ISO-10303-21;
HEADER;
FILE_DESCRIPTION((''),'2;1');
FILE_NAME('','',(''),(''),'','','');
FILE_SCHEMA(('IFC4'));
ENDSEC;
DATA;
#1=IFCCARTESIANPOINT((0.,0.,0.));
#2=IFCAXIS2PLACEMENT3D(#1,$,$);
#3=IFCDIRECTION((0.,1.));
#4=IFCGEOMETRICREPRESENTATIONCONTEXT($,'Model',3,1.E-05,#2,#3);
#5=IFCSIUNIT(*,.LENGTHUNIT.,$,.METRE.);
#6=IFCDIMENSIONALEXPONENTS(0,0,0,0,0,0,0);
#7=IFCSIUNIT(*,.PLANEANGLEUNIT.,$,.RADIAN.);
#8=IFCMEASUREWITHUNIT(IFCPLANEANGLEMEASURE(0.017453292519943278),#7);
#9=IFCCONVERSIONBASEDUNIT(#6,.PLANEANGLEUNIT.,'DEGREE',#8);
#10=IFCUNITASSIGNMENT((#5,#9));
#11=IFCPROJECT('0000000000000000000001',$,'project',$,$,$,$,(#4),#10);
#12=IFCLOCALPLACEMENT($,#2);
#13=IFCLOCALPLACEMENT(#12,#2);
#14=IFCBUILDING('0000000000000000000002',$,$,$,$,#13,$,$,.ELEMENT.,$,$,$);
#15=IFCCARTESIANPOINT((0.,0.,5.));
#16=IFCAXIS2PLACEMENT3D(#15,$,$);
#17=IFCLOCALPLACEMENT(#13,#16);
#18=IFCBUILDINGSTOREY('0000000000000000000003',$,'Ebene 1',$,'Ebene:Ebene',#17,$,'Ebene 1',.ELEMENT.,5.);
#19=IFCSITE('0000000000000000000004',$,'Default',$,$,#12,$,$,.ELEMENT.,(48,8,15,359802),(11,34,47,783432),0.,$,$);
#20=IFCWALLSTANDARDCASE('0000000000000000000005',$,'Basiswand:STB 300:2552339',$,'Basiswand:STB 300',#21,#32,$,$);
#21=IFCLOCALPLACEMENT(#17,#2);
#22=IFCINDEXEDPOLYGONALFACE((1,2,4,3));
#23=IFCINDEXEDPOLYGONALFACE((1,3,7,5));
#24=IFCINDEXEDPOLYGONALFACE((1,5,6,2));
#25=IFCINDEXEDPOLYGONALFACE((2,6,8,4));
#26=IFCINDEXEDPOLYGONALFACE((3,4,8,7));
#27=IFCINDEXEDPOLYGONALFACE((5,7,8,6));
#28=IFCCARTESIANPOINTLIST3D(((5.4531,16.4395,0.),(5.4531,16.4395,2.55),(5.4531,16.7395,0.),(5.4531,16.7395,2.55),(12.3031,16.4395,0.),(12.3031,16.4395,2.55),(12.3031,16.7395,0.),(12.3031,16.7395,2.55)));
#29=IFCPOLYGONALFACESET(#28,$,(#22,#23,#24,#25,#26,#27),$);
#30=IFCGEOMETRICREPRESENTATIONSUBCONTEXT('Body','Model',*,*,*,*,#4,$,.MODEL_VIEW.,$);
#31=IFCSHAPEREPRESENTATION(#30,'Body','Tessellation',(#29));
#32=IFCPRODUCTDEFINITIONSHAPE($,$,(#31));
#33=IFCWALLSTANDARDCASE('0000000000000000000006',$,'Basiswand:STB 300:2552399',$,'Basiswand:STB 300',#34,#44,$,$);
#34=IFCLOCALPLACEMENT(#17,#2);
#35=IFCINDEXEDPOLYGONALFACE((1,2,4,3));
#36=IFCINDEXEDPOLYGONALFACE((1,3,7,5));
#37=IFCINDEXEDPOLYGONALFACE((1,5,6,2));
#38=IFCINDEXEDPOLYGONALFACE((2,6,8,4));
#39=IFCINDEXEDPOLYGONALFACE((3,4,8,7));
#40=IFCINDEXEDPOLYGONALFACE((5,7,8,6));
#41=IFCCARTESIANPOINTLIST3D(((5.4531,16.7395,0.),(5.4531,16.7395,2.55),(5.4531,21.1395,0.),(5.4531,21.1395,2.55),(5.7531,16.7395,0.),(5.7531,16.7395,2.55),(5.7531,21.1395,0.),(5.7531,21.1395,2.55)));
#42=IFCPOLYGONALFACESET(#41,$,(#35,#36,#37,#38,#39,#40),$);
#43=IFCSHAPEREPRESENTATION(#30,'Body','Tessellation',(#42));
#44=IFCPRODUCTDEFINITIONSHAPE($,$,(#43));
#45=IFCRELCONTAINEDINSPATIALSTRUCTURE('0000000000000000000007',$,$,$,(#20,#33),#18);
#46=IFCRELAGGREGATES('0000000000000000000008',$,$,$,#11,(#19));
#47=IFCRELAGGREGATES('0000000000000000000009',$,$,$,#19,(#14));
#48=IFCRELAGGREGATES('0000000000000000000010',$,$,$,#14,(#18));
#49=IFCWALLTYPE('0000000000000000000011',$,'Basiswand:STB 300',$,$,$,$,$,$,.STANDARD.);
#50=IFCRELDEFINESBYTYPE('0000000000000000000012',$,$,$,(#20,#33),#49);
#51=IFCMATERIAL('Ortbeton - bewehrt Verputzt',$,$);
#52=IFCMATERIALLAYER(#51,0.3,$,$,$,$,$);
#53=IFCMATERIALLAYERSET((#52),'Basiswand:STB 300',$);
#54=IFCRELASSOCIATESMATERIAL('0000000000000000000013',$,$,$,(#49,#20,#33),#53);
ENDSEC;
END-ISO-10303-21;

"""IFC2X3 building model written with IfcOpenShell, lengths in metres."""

from ifc_helpers import new_model, entity, si_unit, converted_unit, direction, frame, frame_2d, origin, place, context, subcontext, project, spatial, polyline, rectangle, extrude, clip, bounded_halfspace, material, layer, layer_set, layer_usage, type_object, element, save


model = new_model("IFC2X3")

# Units and contexts
model_context = context("Model", 3, precision=1e-05, world=origin(), true_north=direction((0.0, 1.0)))
body_context = subcontext(model_context, "Body", "Model", "MODEL_VIEW")
ifc_project = project(units=[si_unit("LENGTHUNIT", "METRE"), converted_unit("PLANEANGLEUNIT", "DEGREE", entity("IfcPlaneAngleMeasure", 0.017453292519943278), si_unit("PLANEANGLEUNIT", "RADIAN"), dimensions=[0, 0, 0, 0, 0, 0, 0])], contexts=[model_context])

# Site, building, storey
site_placement = place(None, origin())
site = spatial("IfcSite", under=ifc_project, at=site_placement, Name="Default", CompositionType="ELEMENT", RefLatitude=(48, 8, 15, 359802), RefLongitude=(11, 34, 47, 783432), RefElevation=0.0)
building_placement = place(site_placement, origin())
building = spatial("IfcBuilding", under=site, at=building_placement, CompositionType="ELEMENT")
storey_placement = place(building_placement, frame((0.0, 0.0, 5.0)))
storey = spatial("IfcBuildingStorey", under=building, at=storey_placement, Name="Ebene 1", ObjectType="Ebene:Ebene", LongName="Ebene 1", CompositionType="ELEMENT", Elevation=5.0)

# Shared definitions
ifc_material_1 = material(Name="Ortbeton - bewehrt Verputzt")

# Shared definitions
ifc_layer = layer(ifc_material_1, 0.3)
ifc_layer_set = layer_set([ifc_layer], Name="Basiswand:STB 300")
wall_type = type_object("IfcWallType", Name="Basiswand:STB 300", PredefinedType="STANDARD", material=ifc_layer_set)

# Walls
ifc_layer_usage_1 = layer_usage(ifc_layer_set, "AXIS2", "NEGATIVE", 0.15)
wall_1_placement = place(storey_placement, frame((12.3031, 16.5895, 0.0), z_axis=(0.0, 0.0, 1.0), x_axis=(-1.0, 0.0, 0.0)))
element("IfcWallStandardCase", 1, at=wall_1_placement, inside=storey, type_object=wall_type, material=ifc_layer_usage_1, Name="Basiswand:STB 300:2552339", ObjectType="Basiswand:STB 300", context=body_context, shape_type="Clipping", body=[
    clip(extrude(rectangle(XDim=6.85, YDim=0.3, at=frame_2d((3.425, 0.0), x_axis=(-1.0, 0.0))), origin(), (0.0, 0.0, 1.0), 2.55), bounded_halfspace(frame((0.0, -0.15, 2.55), z_axis=(0.0, 0.0, -1.0), x_axis=(0.0, 1.0, 0.0)), True, frame((0.0, -0.15, 2.55)), polyline([(0.0, 0.0), (6.55, 0.0), (6.85, 0.0), (6.85, 0.3), (0.0, 0.3), (0.0, 0.0)]))),
])
ifc_layer_usage_2 = layer_usage(ifc_layer_set, "AXIS2", "NEGATIVE", 0.15)
wall_2_placement = place(storey_placement, frame((5.6031, 16.7395, 0.0), z_axis=(0.0, 0.0, 1.0), x_axis=(0.0, 1.0, 0.0)))
element("IfcWallStandardCase", 2, at=wall_2_placement, inside=storey, type_object=wall_type, material=ifc_layer_usage_2, Name="Basiswand:STB 300:2552399", ObjectType="Basiswand:STB 300", context=body_context, shape_type="Clipping", body=[
    clip(extrude(rectangle(XDim=4.4, YDim=0.3, at=frame_2d((2.2, 0.0), x_axis=(-1.0, 0.0))), origin(), (0.0, 0.0, 1.0), 2.55), bounded_halfspace(frame((0.0, -0.15, 2.55), z_axis=(0.0, 0.0, -1.0), x_axis=(-1.0, 0.0, 0.0)), True, frame((0.0, -0.15, 2.55)), polyline([(0.0, 0.0), (4.4, 0.0), (4.4, 0.3), (0.0, 0.3), (0.0, 0.0)]))),
])

save(model, "model.ifc")
